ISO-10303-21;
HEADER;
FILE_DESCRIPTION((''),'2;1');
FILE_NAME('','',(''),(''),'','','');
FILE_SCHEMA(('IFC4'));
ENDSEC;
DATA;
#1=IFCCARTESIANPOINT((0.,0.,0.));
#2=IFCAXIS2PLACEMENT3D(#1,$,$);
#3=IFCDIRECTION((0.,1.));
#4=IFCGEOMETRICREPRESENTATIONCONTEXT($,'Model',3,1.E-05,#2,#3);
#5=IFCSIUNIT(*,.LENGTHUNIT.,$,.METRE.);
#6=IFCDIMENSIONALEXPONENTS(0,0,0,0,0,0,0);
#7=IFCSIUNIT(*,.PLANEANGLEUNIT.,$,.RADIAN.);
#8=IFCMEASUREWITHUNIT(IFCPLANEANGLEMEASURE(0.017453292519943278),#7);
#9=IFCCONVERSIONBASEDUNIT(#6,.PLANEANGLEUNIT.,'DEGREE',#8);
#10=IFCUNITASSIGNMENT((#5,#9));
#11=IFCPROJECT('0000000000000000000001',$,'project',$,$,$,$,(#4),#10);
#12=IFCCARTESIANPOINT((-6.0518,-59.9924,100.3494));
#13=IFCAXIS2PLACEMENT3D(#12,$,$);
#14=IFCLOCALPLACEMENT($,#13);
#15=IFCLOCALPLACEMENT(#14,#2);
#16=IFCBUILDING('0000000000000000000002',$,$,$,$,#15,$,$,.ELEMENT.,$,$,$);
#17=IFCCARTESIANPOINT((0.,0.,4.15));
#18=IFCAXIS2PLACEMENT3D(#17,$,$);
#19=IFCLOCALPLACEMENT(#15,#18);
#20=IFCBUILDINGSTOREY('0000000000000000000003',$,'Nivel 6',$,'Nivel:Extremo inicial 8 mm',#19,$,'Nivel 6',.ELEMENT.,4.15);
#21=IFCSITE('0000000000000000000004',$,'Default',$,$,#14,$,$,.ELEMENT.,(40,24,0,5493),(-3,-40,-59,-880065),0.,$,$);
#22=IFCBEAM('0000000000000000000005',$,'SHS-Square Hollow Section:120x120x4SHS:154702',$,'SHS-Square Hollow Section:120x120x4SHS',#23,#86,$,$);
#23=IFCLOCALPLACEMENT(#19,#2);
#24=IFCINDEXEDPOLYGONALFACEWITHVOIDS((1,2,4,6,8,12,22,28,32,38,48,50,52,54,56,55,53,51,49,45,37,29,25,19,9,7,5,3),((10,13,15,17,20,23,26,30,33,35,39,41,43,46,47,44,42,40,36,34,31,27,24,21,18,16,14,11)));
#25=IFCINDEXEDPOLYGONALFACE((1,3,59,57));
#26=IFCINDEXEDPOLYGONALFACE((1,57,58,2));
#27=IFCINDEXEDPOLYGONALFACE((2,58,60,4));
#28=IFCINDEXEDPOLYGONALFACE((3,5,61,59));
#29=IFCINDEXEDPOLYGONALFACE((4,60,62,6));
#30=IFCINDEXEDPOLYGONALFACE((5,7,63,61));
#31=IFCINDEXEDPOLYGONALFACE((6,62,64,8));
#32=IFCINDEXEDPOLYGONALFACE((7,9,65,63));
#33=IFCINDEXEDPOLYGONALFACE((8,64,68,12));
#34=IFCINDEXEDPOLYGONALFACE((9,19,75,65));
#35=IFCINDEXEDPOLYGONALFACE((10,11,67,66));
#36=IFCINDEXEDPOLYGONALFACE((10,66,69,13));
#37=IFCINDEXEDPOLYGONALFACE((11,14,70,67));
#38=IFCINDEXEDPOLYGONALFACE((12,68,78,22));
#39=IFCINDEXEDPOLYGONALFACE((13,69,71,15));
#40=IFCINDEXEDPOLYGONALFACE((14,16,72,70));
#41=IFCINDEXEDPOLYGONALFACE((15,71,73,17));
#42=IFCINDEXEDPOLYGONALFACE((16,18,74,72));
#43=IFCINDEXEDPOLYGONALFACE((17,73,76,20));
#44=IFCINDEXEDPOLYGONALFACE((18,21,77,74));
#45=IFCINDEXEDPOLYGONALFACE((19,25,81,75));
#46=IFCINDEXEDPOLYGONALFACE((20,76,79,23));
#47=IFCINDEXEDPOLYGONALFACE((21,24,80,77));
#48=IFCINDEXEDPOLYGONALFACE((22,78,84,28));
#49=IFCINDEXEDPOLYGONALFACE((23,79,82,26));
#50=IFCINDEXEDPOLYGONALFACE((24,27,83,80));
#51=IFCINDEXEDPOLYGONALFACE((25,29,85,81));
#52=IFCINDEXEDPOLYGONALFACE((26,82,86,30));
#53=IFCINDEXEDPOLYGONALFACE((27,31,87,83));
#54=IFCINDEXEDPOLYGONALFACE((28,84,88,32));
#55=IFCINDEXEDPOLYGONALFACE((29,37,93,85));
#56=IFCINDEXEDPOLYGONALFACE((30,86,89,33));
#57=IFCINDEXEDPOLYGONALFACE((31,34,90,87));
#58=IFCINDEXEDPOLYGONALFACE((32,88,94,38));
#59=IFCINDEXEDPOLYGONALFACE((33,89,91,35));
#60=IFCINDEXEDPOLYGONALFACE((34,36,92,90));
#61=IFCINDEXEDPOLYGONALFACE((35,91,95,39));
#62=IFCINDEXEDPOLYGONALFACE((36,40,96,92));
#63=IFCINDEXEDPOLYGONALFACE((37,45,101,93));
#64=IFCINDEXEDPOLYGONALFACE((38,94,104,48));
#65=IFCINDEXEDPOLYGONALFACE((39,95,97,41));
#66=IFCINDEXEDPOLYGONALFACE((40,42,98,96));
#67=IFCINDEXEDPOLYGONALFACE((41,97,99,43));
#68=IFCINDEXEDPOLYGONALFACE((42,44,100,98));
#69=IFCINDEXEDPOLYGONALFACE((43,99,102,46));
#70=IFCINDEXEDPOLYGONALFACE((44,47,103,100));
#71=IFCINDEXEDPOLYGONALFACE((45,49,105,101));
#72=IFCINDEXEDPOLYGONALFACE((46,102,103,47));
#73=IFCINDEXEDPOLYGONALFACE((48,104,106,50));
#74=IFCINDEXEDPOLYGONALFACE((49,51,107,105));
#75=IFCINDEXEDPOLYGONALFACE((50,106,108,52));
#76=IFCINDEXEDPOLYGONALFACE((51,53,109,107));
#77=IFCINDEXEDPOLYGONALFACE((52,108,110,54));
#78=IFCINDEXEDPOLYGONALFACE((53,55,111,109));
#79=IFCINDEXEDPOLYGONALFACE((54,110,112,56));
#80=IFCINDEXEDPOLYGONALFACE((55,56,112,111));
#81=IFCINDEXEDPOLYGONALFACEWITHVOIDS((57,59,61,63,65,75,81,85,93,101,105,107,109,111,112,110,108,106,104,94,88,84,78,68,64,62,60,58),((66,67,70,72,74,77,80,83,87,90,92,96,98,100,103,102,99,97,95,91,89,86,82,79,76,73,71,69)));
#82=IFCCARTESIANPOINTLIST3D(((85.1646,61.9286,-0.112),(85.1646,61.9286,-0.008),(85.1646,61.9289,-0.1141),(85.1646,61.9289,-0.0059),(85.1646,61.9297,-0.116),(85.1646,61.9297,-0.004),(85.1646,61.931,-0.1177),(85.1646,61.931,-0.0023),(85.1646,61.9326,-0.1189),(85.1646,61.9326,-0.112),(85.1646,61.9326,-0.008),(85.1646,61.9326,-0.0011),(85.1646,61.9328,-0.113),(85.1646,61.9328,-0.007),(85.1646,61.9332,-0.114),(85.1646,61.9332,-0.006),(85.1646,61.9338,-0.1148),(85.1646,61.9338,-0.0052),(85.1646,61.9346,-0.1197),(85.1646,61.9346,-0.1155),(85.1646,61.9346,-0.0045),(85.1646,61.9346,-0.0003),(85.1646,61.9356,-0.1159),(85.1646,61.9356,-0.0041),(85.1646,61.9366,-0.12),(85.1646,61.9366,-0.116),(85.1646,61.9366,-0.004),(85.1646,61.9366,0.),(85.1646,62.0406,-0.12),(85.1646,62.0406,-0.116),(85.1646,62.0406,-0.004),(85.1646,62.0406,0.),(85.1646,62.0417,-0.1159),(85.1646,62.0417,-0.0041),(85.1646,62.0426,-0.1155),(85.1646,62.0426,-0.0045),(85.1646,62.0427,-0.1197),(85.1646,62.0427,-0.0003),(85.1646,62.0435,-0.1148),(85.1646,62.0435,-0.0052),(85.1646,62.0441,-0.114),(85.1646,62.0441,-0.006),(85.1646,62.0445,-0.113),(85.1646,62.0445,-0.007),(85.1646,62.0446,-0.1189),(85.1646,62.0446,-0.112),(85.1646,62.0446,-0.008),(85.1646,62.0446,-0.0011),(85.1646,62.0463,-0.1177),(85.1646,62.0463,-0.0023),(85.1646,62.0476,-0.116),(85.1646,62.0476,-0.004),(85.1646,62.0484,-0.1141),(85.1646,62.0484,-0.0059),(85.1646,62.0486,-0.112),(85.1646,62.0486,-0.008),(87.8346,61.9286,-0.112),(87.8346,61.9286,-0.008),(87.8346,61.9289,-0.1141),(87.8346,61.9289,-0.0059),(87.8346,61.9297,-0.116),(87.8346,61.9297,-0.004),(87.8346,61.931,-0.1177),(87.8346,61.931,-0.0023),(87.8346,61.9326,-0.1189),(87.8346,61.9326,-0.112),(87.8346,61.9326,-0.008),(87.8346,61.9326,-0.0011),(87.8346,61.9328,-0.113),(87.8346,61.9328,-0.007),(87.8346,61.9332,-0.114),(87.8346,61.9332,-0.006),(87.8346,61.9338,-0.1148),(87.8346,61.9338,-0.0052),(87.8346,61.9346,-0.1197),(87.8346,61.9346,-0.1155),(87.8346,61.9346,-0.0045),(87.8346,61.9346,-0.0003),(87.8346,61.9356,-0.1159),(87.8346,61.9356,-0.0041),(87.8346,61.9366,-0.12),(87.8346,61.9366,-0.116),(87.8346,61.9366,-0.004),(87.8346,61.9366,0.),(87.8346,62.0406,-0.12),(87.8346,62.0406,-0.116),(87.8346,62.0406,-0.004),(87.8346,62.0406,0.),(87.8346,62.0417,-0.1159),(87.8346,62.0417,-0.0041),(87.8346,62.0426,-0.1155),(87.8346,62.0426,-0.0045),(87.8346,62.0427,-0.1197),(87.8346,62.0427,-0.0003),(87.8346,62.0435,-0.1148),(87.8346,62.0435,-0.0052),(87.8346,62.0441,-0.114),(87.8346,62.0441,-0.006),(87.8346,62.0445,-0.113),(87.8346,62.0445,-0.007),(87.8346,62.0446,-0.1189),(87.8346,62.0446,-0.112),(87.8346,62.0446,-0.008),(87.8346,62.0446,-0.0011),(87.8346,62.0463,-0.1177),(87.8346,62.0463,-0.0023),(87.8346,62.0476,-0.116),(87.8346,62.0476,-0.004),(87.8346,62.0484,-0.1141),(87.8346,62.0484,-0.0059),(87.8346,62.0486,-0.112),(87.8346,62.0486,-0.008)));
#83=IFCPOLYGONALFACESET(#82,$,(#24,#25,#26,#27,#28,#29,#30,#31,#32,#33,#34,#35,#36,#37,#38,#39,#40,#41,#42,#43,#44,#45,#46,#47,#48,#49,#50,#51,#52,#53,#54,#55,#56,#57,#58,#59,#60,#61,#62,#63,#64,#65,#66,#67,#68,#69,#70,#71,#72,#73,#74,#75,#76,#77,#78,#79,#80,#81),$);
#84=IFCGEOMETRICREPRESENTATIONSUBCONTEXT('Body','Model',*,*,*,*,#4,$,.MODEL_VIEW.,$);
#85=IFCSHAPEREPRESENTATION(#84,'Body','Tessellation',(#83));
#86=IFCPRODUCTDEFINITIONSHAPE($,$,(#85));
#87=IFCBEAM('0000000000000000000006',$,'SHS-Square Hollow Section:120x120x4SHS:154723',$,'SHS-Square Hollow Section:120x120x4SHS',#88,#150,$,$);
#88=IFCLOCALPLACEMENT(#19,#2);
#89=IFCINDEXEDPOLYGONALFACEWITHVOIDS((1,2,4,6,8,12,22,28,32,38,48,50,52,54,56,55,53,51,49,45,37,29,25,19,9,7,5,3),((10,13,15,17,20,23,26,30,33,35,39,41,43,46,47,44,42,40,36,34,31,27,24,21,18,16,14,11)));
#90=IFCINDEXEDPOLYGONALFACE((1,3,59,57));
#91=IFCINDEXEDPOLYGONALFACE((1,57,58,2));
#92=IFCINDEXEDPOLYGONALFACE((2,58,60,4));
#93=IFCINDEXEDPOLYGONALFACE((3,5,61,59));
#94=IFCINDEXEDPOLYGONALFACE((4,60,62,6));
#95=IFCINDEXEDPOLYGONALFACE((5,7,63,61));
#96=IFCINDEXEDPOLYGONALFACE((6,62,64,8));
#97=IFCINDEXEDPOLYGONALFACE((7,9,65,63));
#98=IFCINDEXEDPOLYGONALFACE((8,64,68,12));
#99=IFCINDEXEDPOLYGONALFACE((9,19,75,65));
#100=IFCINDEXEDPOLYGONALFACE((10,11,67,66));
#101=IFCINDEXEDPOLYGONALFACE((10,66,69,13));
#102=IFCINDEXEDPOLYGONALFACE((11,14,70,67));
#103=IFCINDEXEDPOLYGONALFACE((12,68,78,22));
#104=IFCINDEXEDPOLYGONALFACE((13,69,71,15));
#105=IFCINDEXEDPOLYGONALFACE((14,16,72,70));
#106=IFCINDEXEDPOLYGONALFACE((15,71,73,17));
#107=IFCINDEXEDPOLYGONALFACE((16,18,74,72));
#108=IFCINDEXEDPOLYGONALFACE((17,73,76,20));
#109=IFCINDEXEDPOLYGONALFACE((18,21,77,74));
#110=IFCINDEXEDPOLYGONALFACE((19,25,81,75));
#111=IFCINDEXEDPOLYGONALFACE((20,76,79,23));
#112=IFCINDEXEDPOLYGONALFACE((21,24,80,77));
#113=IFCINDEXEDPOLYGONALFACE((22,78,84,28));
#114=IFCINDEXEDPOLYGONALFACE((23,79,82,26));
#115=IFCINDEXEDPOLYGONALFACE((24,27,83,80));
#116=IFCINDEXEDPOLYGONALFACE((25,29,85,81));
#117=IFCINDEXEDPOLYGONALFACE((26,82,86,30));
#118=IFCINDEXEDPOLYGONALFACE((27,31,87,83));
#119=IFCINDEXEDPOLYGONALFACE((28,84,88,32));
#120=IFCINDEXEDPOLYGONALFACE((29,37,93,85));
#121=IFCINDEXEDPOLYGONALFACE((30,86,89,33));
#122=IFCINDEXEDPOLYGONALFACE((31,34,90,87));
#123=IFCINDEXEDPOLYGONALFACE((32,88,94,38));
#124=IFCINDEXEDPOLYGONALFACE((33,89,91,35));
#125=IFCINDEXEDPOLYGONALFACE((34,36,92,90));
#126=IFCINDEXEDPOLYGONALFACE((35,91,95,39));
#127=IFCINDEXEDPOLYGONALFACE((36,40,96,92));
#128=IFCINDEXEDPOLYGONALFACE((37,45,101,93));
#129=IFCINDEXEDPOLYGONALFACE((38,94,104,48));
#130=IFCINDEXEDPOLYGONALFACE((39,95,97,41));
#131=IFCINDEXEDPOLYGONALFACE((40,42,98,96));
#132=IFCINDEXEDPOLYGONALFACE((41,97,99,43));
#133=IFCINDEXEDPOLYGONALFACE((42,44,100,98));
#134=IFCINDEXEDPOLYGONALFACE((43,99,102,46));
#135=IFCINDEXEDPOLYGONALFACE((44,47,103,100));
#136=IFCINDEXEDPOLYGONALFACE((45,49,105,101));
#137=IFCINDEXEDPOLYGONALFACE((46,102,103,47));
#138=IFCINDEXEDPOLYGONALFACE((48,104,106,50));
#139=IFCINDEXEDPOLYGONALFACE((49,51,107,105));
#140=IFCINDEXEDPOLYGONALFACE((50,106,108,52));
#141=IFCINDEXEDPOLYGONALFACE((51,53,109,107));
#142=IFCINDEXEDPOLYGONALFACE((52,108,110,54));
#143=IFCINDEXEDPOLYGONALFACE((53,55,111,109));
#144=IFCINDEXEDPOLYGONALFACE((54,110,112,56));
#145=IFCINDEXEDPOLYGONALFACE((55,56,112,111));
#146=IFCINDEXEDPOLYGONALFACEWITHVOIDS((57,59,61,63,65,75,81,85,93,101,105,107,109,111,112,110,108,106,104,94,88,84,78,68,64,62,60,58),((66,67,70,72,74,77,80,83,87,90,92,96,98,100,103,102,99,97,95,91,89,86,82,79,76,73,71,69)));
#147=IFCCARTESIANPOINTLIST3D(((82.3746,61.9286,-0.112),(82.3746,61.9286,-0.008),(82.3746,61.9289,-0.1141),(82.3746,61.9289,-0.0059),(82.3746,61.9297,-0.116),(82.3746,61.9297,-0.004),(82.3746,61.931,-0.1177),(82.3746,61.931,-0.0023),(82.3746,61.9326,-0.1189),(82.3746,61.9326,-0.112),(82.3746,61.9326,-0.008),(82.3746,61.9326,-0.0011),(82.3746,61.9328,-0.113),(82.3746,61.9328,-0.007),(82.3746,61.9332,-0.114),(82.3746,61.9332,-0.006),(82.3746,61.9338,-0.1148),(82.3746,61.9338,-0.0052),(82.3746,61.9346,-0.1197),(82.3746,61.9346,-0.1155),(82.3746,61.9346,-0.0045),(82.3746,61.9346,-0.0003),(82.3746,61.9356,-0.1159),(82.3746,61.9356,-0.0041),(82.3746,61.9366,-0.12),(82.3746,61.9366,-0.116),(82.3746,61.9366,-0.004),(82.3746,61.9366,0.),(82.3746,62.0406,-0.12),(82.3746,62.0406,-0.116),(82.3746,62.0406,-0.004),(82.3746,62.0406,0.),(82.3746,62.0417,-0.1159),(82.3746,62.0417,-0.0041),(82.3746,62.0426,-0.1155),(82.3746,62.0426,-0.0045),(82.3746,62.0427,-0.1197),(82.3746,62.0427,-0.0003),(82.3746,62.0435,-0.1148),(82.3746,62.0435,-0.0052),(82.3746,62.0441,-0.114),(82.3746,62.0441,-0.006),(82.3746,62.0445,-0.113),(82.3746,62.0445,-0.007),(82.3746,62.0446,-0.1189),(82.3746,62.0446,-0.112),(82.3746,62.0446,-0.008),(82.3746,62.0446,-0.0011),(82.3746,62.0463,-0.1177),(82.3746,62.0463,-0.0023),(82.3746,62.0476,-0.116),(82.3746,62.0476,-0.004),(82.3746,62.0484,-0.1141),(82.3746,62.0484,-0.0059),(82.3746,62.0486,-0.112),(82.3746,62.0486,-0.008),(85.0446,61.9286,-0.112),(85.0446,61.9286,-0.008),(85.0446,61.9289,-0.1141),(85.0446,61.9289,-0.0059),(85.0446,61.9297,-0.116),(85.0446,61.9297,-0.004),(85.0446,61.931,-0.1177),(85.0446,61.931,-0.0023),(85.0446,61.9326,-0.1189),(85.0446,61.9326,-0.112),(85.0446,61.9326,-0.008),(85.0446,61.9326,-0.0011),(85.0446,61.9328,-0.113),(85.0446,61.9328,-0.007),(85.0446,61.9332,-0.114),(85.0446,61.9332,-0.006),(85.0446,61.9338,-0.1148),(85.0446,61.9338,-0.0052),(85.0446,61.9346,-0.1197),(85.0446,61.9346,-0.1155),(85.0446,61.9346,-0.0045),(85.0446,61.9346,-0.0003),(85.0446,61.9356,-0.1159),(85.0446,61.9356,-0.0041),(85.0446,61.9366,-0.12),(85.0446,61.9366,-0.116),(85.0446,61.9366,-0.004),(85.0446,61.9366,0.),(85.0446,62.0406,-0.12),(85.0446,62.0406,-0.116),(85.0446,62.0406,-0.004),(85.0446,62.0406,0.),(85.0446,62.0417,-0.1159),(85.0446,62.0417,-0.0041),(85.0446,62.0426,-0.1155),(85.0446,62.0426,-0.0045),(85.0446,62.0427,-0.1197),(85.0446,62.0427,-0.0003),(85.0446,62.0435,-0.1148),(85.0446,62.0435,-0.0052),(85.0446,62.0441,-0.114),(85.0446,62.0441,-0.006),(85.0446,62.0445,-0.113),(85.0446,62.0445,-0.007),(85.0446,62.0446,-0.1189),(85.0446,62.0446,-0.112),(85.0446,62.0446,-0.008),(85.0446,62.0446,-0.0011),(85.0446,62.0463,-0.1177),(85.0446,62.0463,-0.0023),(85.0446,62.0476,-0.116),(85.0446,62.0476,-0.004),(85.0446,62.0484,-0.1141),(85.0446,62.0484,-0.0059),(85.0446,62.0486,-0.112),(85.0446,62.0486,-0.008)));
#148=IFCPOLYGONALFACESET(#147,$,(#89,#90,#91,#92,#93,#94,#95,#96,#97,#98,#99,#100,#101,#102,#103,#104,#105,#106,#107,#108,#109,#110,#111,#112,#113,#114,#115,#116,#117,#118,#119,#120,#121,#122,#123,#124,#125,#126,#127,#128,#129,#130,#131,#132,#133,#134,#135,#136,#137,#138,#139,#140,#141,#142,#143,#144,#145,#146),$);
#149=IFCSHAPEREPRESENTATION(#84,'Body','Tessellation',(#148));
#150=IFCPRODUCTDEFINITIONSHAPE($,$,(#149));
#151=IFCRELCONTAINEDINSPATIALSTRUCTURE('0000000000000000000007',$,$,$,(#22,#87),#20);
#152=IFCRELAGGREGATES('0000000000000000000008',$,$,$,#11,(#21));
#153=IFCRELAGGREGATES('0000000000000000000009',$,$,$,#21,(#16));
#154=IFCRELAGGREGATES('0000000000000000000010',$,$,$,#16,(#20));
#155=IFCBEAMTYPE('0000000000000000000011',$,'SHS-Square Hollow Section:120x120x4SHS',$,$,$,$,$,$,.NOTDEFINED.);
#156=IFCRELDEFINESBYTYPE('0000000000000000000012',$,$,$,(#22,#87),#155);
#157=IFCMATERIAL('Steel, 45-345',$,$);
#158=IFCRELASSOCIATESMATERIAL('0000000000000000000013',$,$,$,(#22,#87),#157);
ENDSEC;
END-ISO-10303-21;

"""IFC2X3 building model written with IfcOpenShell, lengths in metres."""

from ifc_helpers import new_model, entity, si_unit, converted_unit, direction, frame, frame_2d, origin, place, context, subcontext, project, spatial, polyline, circle_curve, parameter, trimmed, segment, composite_curve, outline, extrude, material, type_object, element, save


model = new_model("IFC2X3")

# Units and contexts
model_context = context("Model", 3, precision=1e-05, world=origin(), true_north=direction((0.0, 1.0)))
body_context = subcontext(model_context, "Body", "Model", "MODEL_VIEW")
ifc_project = project(units=[si_unit("LENGTHUNIT", "METRE"), converted_unit("PLANEANGLEUNIT", "DEGREE", entity("IfcPlaneAngleMeasure", 0.017453292519943278), si_unit("PLANEANGLEUNIT", "RADIAN"), dimensions=[0, 0, 0, 0, 0, 0, 0])], contexts=[model_context])

# Site, building, storey
site_placement = place(None, frame((-6.0518, -59.9924, 100.3494)))
site = spatial("IfcSite", under=ifc_project, at=site_placement, Name="Default", CompositionType="ELEMENT", RefLatitude=(40, 24, 0, 5493), RefLongitude=(-3, -40, -59, -880065), RefElevation=0.0)
building_placement = place(site_placement, origin())
building = spatial("IfcBuilding", under=site, at=building_placement, CompositionType="ELEMENT")
storey_placement = place(building_placement, frame((0.0, 0.0, 4.15)))
storey = spatial("IfcBuildingStorey", under=building, at=storey_placement, Name="Nivel 6", ObjectType="Nivel:Extremo inicial 8 mm", LongName="Nivel 6", CompositionType="ELEMENT", Elevation=4.15)

# Beams
ifc_material_1 = material(Name="Steel, 45-345")
beam_type = type_object("IfcBeamType", Name="SHS-Square Hollow Section:120x120x4SHS", PredefinedType="NOTDEFINED")
beam_1_placement = place(storey_placement, frame((87.8946, 61.9886, 0.0), z_axis=(0.0, 0.0, 1.0), x_axis=(-1.0, 0.0, 0.0)))
element("IfcBeam", 1, at=beam_1_placement, inside=storey, type_object=beam_type, material=ifc_material_1, Name="SHS-Square Hollow Section:120x120x4SHS:154702", ObjectType="SHS-Square Hollow Section:120x120x4SHS", context=body_context, shape_type="SweptSolid", body=[
    extrude(outline(composite_curve([segment(trimmed(circle_curve(frame_2d((-0.052, -0.052), x_axis=(1.0, 0.0)), 0.008), [parameter(180.0)], [parameter(270.0)], True, "PARAMETER"), True, "CONTINUOUS"), segment(polyline([(-0.052, -0.06), (0.052, -0.06)]), True, "CONTINUOUS"), segment(trimmed(circle_curve(frame_2d((0.052, -0.052), x_axis=(1.0, 0.0)), 0.008), [parameter(270.0)], [parameter(0.0)], True, "PARAMETER"), True, "CONTINUOUS"), segment(polyline([(0.06, -0.052), (0.06, 0.052)]), True, "CONTINUOUS"), segment(trimmed(circle_curve(frame_2d((0.052, 0.052), x_axis=(1.0, 0.0)), 0.008), [parameter(360.0)], [parameter(90.0)], True, "PARAMETER"), True, "CONTINUOUS"), segment(polyline([(0.052, 0.06), (-0.052, 0.06)]), True, "CONTINUOUS"), segment(trimmed(circle_curve(frame_2d((-0.052, 0.052), x_axis=(1.0, 0.0)), 0.008), [parameter(90.0)], [parameter(180.0)], True, "PARAMETER"), True, "CONTINUOUS"), segment(polyline([(-0.06, 0.052), (-0.06, -0.052)]), True, "CONTINUOUS")], self_intersect=False), holes=[composite_curve([segment(polyline([(0.052, -0.056), (-0.052, -0.056)]), True, "CONTINUOUS"), segment(trimmed(circle_curve(frame_2d((-0.052, -0.052), x_axis=(1.0, 0.0)), 0.004), [parameter(180.0)], [parameter(270.0)], True, "PARAMETER"), False, "CONTINUOUS"), segment(polyline([(-0.056, -0.052), (-0.056, 0.052)]), True, "CONTINUOUS"), segment(trimmed(circle_curve(frame_2d((-0.052, 0.052), x_axis=(1.0, 0.0)), 0.004), [parameter(90.0)], [parameter(180.0)], True, "PARAMETER"), False, "CONTINUOUS"), segment(polyline([(-0.052, 0.056), (0.052, 0.056)]), True, "CONTINUOUS"), segment(trimmed(circle_curve(frame_2d((0.052, 0.052), x_axis=(1.0, 0.0)), 0.004), [parameter(0.0)], [parameter(90.0)], True, "PARAMETER"), False, "CONTINUOUS"), segment(polyline([(0.056, 0.052), (0.056, -0.052)]), True, "CONTINUOUS"), segment(trimmed(circle_curve(frame_2d((0.052, -0.052), x_axis=(1.0, 0.0)), 0.004), [parameter(270.0)], [parameter(0.0)], True, "PARAMETER"), False, "CONTINUOUS")], self_intersect=False)]), frame((0.06, 0.0, -0.06), z_axis=(1.0, 0.0, 0.0), x_axis=(0.0, -1.0, 0.0)), (0.0, 0.0, 1.0), 2.67),
])
beam_2_placement = place(storey_placement, frame((85.1046, 61.9886, 0.0), z_axis=(0.0, 0.0, 1.0), x_axis=(-1.0, 0.0, 0.0)))
element("IfcBeam", 2, at=beam_2_placement, inside=storey, type_object=beam_type, material=ifc_material_1, Name="SHS-Square Hollow Section:120x120x4SHS:154723", ObjectType="SHS-Square Hollow Section:120x120x4SHS", context=body_context, shape_type="SweptSolid", body=[
    extrude(outline(composite_curve([segment(trimmed(circle_curve(frame_2d((-0.052, -0.052), x_axis=(1.0, 0.0)), 0.008), [parameter(180.0)], [parameter(270.0)], True, "PARAMETER"), True, "CONTINUOUS"), segment(polyline([(-0.052, -0.06), (0.052, -0.06)]), True, "CONTINUOUS"), segment(trimmed(circle_curve(frame_2d((0.052, -0.052), x_axis=(1.0, 0.0)), 0.008), [parameter(270.0)], [parameter(0.0)], True, "PARAMETER"), True, "CONTINUOUS"), segment(polyline([(0.06, -0.052), (0.06, 0.052)]), True, "CONTINUOUS"), segment(trimmed(circle_curve(frame_2d((0.052, 0.052), x_axis=(1.0, 0.0)), 0.008), [parameter(360.0)], [parameter(90.0)], True, "PARAMETER"), True, "CONTINUOUS"), segment(polyline([(0.052, 0.06), (-0.052, 0.06)]), True, "CONTINUOUS"), segment(trimmed(circle_curve(frame_2d((-0.052, 0.052), x_axis=(1.0, 0.0)), 0.008), [parameter(90.0)], [parameter(180.0)], True, "PARAMETER"), True, "CONTINUOUS"), segment(polyline([(-0.06, 0.052), (-0.06, -0.052)]), True, "CONTINUOUS")], self_intersect=False), holes=[composite_curve([segment(polyline([(0.052, -0.056), (-0.052, -0.056)]), True, "CONTINUOUS"), segment(trimmed(circle_curve(frame_2d((-0.052, -0.052), x_axis=(1.0, 0.0)), 0.004), [parameter(180.0)], [parameter(270.0)], True, "PARAMETER"), False, "CONTINUOUS"), segment(polyline([(-0.056, -0.052), (-0.056, 0.052)]), True, "CONTINUOUS"), segment(trimmed(circle_curve(frame_2d((-0.052, 0.052), x_axis=(1.0, 0.0)), 0.004), [parameter(90.0)], [parameter(180.0)], True, "PARAMETER"), False, "CONTINUOUS"), segment(polyline([(-0.052, 0.056), (0.052, 0.056)]), True, "CONTINUOUS"), segment(trimmed(circle_curve(frame_2d((0.052, 0.052), x_axis=(1.0, 0.0)), 0.004), [parameter(0.0)], [parameter(90.0)], True, "PARAMETER"), False, "CONTINUOUS"), segment(polyline([(0.056, 0.052), (0.056, -0.052)]), True, "CONTINUOUS"), segment(trimmed(circle_curve(frame_2d((0.052, -0.052), x_axis=(1.0, 0.0)), 0.004), [parameter(270.0)], [parameter(0.0)], True, "PARAMETER"), False, "CONTINUOUS")], self_intersect=False)]), frame((0.06, 0.0, -0.06), z_axis=(1.0, 0.0, 0.0), x_axis=(0.0, -1.0, 0.0)), (0.0, 0.0, 1.0), 2.67),
])

save(model, "model.ifc")
